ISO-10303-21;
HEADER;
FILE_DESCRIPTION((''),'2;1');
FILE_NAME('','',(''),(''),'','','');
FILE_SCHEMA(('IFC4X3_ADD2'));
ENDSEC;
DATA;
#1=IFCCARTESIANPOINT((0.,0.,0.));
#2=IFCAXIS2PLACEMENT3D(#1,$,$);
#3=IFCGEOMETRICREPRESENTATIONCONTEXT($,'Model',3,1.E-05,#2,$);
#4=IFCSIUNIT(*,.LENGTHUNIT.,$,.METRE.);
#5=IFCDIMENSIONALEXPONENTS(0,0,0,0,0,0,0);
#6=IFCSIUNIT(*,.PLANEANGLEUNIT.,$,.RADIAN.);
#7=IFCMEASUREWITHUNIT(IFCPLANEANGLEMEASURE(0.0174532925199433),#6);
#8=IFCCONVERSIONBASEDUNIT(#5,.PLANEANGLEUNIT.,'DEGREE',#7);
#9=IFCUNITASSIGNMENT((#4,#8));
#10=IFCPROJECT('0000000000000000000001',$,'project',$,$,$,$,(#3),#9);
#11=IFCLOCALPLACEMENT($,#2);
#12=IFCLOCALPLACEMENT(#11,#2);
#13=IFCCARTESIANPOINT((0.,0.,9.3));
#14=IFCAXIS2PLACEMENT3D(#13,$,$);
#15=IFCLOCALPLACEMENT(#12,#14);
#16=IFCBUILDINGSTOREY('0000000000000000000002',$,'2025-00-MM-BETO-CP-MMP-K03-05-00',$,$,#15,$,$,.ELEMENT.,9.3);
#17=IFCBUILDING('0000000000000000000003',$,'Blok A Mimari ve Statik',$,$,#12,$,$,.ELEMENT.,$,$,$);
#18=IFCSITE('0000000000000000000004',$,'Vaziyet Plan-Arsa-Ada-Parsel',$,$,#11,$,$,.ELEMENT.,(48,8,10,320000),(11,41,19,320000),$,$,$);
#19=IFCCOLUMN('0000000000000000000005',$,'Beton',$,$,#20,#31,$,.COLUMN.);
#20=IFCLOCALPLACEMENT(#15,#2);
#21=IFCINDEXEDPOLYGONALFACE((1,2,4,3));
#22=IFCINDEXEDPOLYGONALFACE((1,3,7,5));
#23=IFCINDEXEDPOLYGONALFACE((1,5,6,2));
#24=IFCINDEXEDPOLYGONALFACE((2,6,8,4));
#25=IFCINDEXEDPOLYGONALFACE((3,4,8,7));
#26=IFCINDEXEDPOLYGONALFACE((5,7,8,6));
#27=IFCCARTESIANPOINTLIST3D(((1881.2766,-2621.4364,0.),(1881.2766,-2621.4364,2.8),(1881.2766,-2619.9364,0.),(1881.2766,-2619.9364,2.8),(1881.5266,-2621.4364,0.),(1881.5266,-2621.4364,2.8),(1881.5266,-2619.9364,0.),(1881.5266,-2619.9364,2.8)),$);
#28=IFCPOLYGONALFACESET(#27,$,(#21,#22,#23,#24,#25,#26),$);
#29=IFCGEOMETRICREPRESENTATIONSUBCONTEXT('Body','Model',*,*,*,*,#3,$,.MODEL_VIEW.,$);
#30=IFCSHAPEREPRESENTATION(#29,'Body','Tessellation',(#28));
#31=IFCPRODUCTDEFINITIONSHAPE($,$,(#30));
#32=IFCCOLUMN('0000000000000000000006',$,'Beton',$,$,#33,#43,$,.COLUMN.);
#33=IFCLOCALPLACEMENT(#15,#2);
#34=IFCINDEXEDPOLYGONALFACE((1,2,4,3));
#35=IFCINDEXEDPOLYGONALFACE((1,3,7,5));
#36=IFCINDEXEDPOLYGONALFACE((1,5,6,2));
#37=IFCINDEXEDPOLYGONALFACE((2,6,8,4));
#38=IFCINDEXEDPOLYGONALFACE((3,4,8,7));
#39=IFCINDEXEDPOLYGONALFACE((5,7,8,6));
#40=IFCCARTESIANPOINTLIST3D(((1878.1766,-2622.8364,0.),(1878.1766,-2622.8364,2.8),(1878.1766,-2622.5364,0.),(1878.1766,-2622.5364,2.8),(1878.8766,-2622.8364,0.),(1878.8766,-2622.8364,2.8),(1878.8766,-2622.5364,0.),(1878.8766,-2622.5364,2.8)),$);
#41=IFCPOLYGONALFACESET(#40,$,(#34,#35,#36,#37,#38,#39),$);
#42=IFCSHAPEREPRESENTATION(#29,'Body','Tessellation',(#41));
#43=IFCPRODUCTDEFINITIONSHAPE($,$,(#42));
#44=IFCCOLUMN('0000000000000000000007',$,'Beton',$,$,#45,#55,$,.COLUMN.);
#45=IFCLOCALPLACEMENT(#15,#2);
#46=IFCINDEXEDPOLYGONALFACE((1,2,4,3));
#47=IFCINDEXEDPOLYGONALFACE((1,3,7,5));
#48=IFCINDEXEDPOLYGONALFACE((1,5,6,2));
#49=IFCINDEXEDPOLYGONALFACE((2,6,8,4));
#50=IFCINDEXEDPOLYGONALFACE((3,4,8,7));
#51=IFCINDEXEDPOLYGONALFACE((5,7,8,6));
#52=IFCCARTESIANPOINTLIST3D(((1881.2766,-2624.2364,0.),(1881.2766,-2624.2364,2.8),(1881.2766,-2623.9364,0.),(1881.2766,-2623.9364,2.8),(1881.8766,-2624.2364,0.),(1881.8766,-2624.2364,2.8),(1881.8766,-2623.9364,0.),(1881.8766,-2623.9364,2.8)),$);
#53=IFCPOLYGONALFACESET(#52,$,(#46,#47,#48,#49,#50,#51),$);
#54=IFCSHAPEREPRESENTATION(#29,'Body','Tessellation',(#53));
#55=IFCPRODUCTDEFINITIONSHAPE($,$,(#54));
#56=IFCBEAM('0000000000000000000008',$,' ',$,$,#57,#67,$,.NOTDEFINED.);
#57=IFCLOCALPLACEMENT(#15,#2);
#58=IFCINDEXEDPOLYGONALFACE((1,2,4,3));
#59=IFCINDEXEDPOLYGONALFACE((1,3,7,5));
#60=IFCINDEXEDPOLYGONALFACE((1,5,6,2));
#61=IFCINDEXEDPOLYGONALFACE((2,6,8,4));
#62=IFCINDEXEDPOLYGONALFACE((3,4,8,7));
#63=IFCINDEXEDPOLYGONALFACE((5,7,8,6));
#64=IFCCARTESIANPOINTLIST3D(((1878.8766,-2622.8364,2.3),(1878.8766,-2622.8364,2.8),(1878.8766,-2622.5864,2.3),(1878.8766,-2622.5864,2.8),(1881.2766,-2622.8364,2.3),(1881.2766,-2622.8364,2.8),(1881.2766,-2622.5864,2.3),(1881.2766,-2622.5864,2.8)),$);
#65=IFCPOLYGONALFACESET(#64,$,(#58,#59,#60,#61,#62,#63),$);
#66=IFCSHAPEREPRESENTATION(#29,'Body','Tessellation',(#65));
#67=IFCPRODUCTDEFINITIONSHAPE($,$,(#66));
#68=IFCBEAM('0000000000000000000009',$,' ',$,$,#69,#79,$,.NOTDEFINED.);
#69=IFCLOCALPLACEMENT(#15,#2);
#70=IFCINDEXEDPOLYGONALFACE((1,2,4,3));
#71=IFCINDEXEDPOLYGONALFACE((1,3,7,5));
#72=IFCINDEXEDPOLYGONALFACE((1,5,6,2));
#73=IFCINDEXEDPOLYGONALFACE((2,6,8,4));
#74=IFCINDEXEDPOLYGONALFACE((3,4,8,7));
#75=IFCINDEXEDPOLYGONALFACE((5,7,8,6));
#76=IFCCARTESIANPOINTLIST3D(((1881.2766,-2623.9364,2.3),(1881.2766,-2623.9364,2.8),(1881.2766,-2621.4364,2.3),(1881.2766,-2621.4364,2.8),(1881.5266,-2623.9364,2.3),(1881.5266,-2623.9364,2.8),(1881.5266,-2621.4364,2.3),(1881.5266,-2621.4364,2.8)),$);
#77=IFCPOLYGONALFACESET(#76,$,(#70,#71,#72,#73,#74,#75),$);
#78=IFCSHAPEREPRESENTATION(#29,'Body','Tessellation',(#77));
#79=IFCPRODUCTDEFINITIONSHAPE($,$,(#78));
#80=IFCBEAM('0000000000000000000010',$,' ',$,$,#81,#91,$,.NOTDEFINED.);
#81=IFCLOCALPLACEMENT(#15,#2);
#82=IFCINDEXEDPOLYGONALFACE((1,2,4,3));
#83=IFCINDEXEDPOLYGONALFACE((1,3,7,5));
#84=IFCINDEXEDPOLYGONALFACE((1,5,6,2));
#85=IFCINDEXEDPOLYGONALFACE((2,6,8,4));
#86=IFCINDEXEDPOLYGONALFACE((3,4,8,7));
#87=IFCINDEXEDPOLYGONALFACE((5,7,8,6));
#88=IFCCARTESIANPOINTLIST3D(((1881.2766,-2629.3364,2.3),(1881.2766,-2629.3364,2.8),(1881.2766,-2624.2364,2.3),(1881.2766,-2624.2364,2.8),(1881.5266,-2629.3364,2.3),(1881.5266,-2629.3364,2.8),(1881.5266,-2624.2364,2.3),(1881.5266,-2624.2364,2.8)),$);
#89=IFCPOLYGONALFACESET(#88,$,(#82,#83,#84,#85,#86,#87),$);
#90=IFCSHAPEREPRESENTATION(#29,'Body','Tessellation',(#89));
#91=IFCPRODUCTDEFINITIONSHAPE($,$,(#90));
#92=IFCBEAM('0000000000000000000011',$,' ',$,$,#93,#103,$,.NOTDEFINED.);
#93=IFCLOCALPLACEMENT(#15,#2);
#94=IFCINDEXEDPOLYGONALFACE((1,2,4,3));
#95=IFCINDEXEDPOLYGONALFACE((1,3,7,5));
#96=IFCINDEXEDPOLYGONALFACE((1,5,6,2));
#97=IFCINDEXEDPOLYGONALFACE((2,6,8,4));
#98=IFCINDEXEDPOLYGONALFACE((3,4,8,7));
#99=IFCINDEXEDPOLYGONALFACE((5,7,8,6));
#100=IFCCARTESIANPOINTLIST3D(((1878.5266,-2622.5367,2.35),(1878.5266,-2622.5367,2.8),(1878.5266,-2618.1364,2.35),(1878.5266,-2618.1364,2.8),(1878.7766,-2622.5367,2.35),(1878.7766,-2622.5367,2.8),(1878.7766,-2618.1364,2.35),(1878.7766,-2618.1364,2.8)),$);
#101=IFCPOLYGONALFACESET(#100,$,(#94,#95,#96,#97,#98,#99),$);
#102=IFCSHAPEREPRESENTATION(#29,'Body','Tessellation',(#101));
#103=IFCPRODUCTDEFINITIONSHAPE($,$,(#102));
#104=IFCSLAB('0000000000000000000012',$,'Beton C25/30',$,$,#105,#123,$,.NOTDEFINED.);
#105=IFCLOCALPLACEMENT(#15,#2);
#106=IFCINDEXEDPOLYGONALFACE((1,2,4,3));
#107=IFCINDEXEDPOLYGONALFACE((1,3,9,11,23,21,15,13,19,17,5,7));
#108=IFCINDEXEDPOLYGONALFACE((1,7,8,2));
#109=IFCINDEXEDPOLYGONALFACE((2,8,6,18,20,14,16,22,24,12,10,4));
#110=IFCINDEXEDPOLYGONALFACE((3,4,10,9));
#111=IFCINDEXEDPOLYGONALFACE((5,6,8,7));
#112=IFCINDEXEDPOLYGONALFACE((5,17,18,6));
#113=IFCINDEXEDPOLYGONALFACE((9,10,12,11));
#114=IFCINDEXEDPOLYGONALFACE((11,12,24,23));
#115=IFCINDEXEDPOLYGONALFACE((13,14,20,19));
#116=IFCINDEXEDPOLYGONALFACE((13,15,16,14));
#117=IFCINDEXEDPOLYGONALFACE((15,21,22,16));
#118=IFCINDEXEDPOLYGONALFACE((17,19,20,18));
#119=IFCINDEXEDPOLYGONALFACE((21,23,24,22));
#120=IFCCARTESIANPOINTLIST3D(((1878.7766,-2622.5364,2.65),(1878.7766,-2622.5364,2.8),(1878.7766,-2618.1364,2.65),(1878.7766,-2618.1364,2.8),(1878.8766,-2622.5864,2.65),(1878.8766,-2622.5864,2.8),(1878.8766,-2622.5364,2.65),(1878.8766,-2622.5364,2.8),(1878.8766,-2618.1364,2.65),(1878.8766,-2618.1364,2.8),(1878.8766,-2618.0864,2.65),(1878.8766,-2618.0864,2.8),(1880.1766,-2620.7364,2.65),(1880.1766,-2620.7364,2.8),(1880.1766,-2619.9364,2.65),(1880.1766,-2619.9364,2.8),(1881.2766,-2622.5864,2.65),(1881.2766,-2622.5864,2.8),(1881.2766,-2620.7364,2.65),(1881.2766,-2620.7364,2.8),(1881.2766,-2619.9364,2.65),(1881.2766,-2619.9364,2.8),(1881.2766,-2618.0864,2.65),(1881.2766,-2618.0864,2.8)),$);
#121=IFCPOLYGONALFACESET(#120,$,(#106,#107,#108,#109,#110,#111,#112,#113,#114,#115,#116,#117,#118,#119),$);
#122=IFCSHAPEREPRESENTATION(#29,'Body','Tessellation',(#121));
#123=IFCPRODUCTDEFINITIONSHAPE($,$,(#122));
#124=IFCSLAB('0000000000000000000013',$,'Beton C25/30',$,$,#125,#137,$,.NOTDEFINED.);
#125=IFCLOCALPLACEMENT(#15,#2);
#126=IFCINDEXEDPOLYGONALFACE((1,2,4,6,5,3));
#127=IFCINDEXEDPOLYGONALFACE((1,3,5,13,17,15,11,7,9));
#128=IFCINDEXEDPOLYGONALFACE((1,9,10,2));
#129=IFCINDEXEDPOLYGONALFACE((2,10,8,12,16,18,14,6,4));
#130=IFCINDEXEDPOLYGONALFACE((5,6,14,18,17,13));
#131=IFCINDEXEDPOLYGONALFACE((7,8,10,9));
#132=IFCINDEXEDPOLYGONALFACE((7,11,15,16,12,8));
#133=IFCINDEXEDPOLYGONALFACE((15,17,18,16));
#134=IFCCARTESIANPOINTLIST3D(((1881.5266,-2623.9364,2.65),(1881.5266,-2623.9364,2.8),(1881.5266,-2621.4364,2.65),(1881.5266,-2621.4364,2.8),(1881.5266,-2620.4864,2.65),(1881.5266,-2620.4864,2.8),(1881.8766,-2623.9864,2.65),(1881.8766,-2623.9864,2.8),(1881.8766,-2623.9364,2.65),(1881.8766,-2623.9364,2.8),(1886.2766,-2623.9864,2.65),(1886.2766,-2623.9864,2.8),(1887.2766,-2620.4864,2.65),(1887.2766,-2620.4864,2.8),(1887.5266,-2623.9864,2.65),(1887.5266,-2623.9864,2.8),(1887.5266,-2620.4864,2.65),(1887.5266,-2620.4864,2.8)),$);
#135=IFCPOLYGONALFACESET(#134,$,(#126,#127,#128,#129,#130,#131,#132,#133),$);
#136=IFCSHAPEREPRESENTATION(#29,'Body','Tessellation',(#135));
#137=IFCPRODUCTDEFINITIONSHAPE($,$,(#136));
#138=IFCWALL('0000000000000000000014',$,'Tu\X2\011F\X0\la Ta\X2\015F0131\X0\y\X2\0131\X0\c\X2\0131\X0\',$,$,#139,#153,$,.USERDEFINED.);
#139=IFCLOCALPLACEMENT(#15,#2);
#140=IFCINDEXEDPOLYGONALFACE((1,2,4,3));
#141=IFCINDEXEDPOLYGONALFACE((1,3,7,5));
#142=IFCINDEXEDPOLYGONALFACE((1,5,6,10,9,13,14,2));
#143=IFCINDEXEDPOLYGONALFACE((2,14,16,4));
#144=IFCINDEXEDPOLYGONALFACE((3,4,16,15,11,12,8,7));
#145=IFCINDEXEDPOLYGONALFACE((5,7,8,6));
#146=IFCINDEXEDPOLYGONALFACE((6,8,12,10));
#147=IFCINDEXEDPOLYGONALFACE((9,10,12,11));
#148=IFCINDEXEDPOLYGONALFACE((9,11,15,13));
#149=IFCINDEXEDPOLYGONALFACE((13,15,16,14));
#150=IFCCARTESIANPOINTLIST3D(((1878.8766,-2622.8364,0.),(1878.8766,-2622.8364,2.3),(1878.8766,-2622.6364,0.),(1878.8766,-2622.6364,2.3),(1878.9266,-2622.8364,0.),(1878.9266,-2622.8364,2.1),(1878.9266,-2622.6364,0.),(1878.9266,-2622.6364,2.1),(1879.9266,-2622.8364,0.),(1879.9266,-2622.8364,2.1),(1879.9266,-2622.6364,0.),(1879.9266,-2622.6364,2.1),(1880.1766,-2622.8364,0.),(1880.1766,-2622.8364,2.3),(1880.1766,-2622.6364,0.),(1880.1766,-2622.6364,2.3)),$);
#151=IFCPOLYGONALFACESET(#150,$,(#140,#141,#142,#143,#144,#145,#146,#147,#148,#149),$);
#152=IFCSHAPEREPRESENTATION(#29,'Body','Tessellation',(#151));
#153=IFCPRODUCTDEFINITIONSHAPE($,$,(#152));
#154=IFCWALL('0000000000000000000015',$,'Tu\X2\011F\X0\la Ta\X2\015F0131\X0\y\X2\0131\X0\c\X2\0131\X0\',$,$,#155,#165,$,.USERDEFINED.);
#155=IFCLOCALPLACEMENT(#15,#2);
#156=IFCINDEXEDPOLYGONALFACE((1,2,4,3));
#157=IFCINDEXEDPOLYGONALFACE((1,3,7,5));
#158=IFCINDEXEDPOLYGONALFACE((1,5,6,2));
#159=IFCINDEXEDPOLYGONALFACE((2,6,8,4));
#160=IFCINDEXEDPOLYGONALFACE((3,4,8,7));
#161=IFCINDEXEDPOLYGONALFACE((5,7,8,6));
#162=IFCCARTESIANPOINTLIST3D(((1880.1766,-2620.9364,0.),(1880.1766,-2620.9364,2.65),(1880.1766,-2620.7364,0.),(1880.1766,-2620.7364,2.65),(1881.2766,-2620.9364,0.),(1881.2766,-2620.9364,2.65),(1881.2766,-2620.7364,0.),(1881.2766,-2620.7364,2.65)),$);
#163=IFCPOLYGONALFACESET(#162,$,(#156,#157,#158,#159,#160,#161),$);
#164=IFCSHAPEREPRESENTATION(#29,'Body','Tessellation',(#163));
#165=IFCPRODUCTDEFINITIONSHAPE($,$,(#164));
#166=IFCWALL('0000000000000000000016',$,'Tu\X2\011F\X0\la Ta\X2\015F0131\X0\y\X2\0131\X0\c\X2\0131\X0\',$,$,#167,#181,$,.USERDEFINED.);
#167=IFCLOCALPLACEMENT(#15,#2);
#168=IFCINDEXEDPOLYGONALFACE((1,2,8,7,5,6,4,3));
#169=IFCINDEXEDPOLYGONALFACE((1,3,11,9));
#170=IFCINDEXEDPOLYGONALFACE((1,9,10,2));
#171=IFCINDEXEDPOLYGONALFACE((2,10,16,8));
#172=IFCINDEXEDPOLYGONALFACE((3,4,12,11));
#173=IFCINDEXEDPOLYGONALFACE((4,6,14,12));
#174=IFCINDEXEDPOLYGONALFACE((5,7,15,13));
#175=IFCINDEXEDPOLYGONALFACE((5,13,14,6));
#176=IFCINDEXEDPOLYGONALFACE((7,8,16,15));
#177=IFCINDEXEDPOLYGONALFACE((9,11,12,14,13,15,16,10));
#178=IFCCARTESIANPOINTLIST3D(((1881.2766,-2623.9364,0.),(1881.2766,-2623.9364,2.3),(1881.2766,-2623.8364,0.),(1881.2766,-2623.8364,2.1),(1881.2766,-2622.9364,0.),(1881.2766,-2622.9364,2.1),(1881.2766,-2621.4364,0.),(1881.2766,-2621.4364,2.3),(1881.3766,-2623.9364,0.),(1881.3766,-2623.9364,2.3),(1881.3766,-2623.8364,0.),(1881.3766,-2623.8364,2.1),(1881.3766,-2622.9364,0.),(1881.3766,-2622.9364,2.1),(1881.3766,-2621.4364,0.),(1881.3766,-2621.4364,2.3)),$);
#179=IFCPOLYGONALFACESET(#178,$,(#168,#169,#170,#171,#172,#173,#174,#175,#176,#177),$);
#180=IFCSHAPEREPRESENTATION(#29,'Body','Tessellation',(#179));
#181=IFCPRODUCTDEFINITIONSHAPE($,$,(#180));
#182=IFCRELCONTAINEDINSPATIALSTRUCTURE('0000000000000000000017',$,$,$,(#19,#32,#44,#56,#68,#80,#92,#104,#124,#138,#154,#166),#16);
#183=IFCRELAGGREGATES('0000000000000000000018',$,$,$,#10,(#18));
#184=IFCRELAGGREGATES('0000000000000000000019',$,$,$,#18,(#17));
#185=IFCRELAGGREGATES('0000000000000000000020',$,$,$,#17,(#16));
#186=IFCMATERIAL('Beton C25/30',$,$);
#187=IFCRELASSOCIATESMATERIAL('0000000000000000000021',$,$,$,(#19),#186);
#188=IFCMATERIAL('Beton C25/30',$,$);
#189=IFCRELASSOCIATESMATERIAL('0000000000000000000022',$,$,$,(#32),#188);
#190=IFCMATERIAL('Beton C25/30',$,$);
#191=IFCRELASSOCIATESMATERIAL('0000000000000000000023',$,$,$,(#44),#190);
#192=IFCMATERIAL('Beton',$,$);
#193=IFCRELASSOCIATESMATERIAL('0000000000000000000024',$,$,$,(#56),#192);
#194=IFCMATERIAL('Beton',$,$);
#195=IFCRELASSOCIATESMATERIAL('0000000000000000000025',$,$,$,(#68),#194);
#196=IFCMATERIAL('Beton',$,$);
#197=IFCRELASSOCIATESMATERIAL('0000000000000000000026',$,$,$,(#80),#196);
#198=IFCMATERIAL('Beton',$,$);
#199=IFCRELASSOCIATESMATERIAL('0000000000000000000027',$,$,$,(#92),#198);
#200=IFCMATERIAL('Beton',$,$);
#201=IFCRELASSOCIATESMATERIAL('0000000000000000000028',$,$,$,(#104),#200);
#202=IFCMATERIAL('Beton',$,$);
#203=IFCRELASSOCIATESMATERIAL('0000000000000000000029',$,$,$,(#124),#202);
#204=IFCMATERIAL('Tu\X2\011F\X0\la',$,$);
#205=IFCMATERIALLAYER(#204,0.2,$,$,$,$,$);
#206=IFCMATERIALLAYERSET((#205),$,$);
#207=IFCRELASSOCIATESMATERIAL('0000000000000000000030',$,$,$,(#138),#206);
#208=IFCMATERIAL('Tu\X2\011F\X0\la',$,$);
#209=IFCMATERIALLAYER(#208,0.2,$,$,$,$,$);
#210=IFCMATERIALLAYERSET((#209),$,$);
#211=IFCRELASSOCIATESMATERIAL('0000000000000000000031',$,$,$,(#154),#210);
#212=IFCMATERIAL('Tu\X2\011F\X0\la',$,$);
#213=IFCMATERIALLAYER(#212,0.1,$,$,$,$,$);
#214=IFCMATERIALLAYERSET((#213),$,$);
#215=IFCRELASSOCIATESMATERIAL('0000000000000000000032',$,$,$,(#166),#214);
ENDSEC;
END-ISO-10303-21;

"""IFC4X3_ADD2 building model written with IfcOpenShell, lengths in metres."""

from ifc_helpers import new_model, entity, si_unit, converted_unit, frame, frame_2d, origin, origin_with_axes, place, context, subcontext, project, spatial, polyline, rectangle, outline, extrude, material, layer, layer_set, layer_usage, element, save


model = new_model("IFC4X3_ADD2")

# Units and contexts
model_context = context("Model", 3, precision=1e-05, world=origin())
body_context = subcontext(model_context, "Body", "Model", "MODEL_VIEW")
ifc_project = project(units=[si_unit("LENGTHUNIT", "METRE"), converted_unit("PLANEANGLEUNIT", "DEGREE", entity("IfcPlaneAngleMeasure", 0.0174532925199433), si_unit("PLANEANGLEUNIT", "RADIAN"), dimensions=[0, 0, 0, 0, 0, 0, 0])], contexts=[model_context])

# Site, building, storey
site_placement = place(None, origin())
site = spatial("IfcSite", under=ifc_project, at=site_placement, Name="Vaziyet Plan-Arsa-Ada-Parsel", CompositionType="ELEMENT", RefLatitude=(48, 8, 10, 320000), RefLongitude=(11, 41, 19, 320000))
building_placement = place(site_placement, origin())
building = spatial("IfcBuilding", under=site, at=building_placement, Name="Blok A Mimari ve Statik", CompositionType="ELEMENT")
storey_placement = place(building_placement, frame((0.0, 0.0, 9.3)))
storey = spatial("IfcBuildingStorey", under=building, at=storey_placement, Name="2025-00-MM-BETO-CP-MMP-K03-05-00", CompositionType="ELEMENT", Elevation=9.3)

# Columns
ifc_material_1 = material(Name="Beton C25/30")
column_1_placement = place(storey_placement, frame((1881.2766, -2621.4364, 0.0)))
element("IfcColumn", 1, at=column_1_placement, inside=storey, material=ifc_material_1, Name="Beton", PredefinedType="COLUMN", context=body_context, shape_type="SweptSolid", body=[
    extrude(outline(polyline([(0.0, 0.0), (0.25, 0.0), (0.25, 1.5), (0.0, 1.5), (0.0, 0.0)])), origin_with_axes(), (0.0, 0.0, 1.0), 2.8),
])
ifc_material_2 = material(Name="Beton C25/30")
column_2_placement = place(storey_placement, frame((1878.1766, -2622.8364, 0.0)))
element("IfcColumn", 2, at=column_2_placement, inside=storey, material=ifc_material_2, Name="Beton", PredefinedType="COLUMN", context=body_context, shape_type="SweptSolid", body=[
    extrude(outline(polyline([(0.0, 0.0), (0.7, 0.0), (0.7, 0.3), (0.0, 0.3), (0.0, 0.0)])), origin_with_axes(), (0.0, 0.0, 1.0), 2.8),
])
ifc_material_3 = material(Name="Beton C25/30")
column_3_placement = place(storey_placement, frame((1881.2766, -2624.2364, 0.0)))
element("IfcColumn", 3, at=column_3_placement, inside=storey, material=ifc_material_3, Name="Beton", PredefinedType="COLUMN", context=body_context, shape_type="SweptSolid", body=[
    extrude(outline(polyline([(0.0, 0.0), (0.6, 0.0), (0.6, 0.3), (0.0, 0.3), (0.0, 0.0)])), origin_with_axes(), (0.0, 0.0, 1.0), 2.8),
])

# Beams
ifc_material_4 = material(Name="Beton")
beam_1_placement = place(storey_placement, frame((1878.8766, -2622.8364, 2.3)))
element("IfcBeam", 4, at=beam_1_placement, inside=storey, material=ifc_material_4, Name=" ", PredefinedType="NOTDEFINED", context=body_context, shape_type="SweptSolid", body=[
    extrude(rectangle(XDim=0.25, YDim=0.5, at=frame_2d((0.125, 0.25), x_axis=(1.0, 0.0))), frame((0.0, 0.0, 0.0), z_axis=(1.0, 0.0, 0.0), x_axis=(0.0, 1.0, 0.0)), (0.0, 0.0, 1.0), 2.4),
])
ifc_material_5 = material(Name="Beton")
beam_2_placement = place(storey_placement, frame((1881.2766, -2621.4364, 2.3), z_axis=(0.0, 0.0, 1.0), x_axis=(0.0, -1.0, 0.0)))
element("IfcBeam", 5, at=beam_2_placement, inside=storey, material=ifc_material_5, Name=" ", PredefinedType="NOTDEFINED", context=body_context, shape_type="SweptSolid", body=[
    extrude(rectangle(XDim=0.25, YDim=0.5, at=frame_2d((0.125, 0.25), x_axis=(1.0, 0.0))), frame((0.0, 0.0, 0.0), z_axis=(1.0, 0.0, 0.0), x_axis=(0.0, 1.0, 0.0)), (0.0, 0.0, 1.0), 2.5),
])
ifc_material_6 = material(Name="Beton")
beam_3_placement = place(storey_placement, frame((1881.2766, -2624.2364, 2.3), z_axis=(0.0, 0.0, 1.0), x_axis=(0.0, -1.0, 0.0)))
element("IfcBeam", 6, at=beam_3_placement, inside=storey, material=ifc_material_6, Name=" ", PredefinedType="NOTDEFINED", context=body_context, shape_type="SweptSolid", body=[
    extrude(rectangle(XDim=0.25, YDim=0.5, at=frame_2d((0.125, 0.25), x_axis=(1.0, 0.0))), frame((0.0, 0.0, 0.0), z_axis=(1.0, 0.0, 0.0), x_axis=(0.0, 1.0, 0.0)), (0.0, 0.0, 1.0), 5.1),
])
ifc_material_7 = material(Name="Beton")
beam_4_placement = place(storey_placement, frame((1878.7766, -2622.5367, 2.35), z_axis=(0.0, 0.0, 1.0), x_axis=(0.0, 1.0, 0.0)))
element("IfcBeam", 7, at=beam_4_placement, inside=storey, material=ifc_material_7, Name=" ", PredefinedType="NOTDEFINED", context=body_context, shape_type="SweptSolid", body=[
    extrude(rectangle(XDim=0.25, YDim=0.45, at=frame_2d((0.125, 0.225), x_axis=(1.0, 0.0))), frame((0.0, 0.0, 0.0), z_axis=(1.0, 0.0, 0.0), x_axis=(0.0, 1.0, 0.0)), (0.0, 0.0, 1.0), 4.4003),
])

# Slab, opening
ifc_material_8 = material(Name="Beton")
slab_1_placement = place(storey_placement, frame((1878.7766, -2622.5864, 2.65)))
slab_1 = element("IfcSlab", 8, at=slab_1_placement, inside=storey, material=ifc_material_8, Name="Beton C25/30", PredefinedType="NOTDEFINED", context=body_context, shape_type="SweptSolid", body=[
    extrude(outline(polyline([(0.1, 4.5), (0.1, 4.45), (0.0, 4.45), (0.0, 0.05), (0.1, 0.05), (0.1, 0.0), (2.5, 0.0), (2.5, 4.5), (0.1, 4.5)])), origin_with_axes(), (0.0, 0.0, 1.0), 0.15),
])
opening_1_placement = place(slab_1_placement, frame((1.4, 1.85, 0.0)))
element("IfcOpeningElement", 9, at=opening_1_placement, cuts=slab_1, PredefinedType="OPENING", context=body_context, shape_type="SweptSolid", body=[
    extrude(rectangle(XDim=1.1, YDim=0.8, at=frame_2d((0.0, 0.0), x_axis=(-1.0, 0.0))), frame((0.55, 0.4, 0.0), z_axis=(0.0, 0.0, 1.0), x_axis=(1.0, 0.0, 0.0)), (0.0, 0.0, 1.0), 0.15),
])

# Slab
ifc_material_9 = material(Name="Beton")
slab_2_placement = place(storey_placement, frame((1881.5266, -2623.9864, 2.65)))
element("IfcSlab", 10, at=slab_2_placement, inside=storey, material=ifc_material_9, Name="Beton C25/30", PredefinedType="NOTDEFINED", context=body_context, shape_type="SweptSolid", body=[
    extrude(outline(polyline([(0.0, 3.5), (0.0, 2.55), (0.0, 0.05), (0.35, 0.05), (0.35, 0.0), (4.75, 0.0), (6.0, 0.0), (6.0, 3.5), (5.75, 3.5), (0.0, 3.5)])), origin_with_axes(), (0.0, 0.0, 1.0), 0.15),
])

# Wall, opening
ifc_material_10 = material(Name="Tuğla")
ifc_layer_1 = layer(ifc_material_10, 0.2)
ifc_layer_set_1 = layer_set([ifc_layer_1])
ifc_layer_usage_1 = layer_usage(ifc_layer_set_1, "AXIS2", "POSITIVE", 0.0)
wall_1_placement = place(storey_placement, frame((1878.8766, -2622.8364, 0.0), z_axis=(0.0, 0.0, 1.0), x_axis=(1.0, 0.000001, 0.0)))
wall_1 = element("IfcWall", 11, at=wall_1_placement, inside=storey, material=ifc_layer_usage_1, Name="Tuğla Taşıyıcı", PredefinedType="USERDEFINED", context=body_context, shape_type="SweptSolid", body=[
    extrude(rectangle(XDim=1.3, YDim=0.2, at=frame_2d((0.65, 0.1), x_axis=(1.0, 0.0))), origin_with_axes(), (0.0, 0.0, 1.0), 2.3),
])
opening_2_placement = place(wall_1_placement, frame((0.05, 0.0, 0.0), z_axis=(0.0, 1.0, 0.0), x_axis=(0.0, 0.0, 1.0)))
element("IfcOpeningElement", 12, at=opening_2_placement, cuts=wall_1, PredefinedType="OPENING", context=body_context, shape_type="SweptSolid", body=[
    extrude(outline(polyline([(2.1, 1.0), (2.1, 0.0), (0.0, 0.0), (0.0, 1.0), (2.1, 1.0)])), origin_with_axes(), (0.0, 0.0, 1.0), 0.2),
])

# Wall
ifc_material_11 = material(Name="Tuğla")
ifc_layer_2 = layer(ifc_material_11, 0.2)
ifc_layer_set_2 = layer_set([ifc_layer_2])
ifc_layer_usage_2 = layer_usage(ifc_layer_set_2, "AXIS2", "POSITIVE", 0.0)
wall_2_placement = place(storey_placement, frame((1880.1766, -2620.9364, 0.0)))
element("IfcWall", 13, at=wall_2_placement, inside=storey, material=ifc_layer_usage_2, Name="Tuğla Taşıyıcı", PredefinedType="USERDEFINED", context=body_context, shape_type="SweptSolid", body=[
    extrude(rectangle(XDim=1.1, YDim=0.2, at=frame_2d((0.55, 0.1), x_axis=(1.0, 0.0))), origin_with_axes(), (0.0, 0.0, 1.0), 2.65),
])

# Wall, opening
ifc_material_12 = material(Name="Tuğla")
ifc_layer_3 = layer(ifc_material_12, 0.1)
ifc_layer_set_3 = layer_set([ifc_layer_3])
ifc_layer_usage_3 = layer_usage(ifc_layer_set_3, "AXIS2", "POSITIVE", 0.0)
wall_3_placement = place(storey_placement, frame((1881.2766, -2621.4364, 0.0), z_axis=(0.0, 0.0, 1.0), x_axis=(0.0, -1.0, 0.0)))
wall_3 = element("IfcWall", 14, at=wall_3_placement, inside=storey, material=ifc_layer_usage_3, Name="Tuğla Taşıyıcı", PredefinedType="USERDEFINED", context=body_context, shape_type="SweptSolid", body=[
    extrude(rectangle(XDim=2.5, YDim=0.1, at=frame_2d((1.25, 0.05), x_axis=(1.0, 0.0))), origin_with_axes(), (0.0, 0.0, 1.0), 2.3),
])
opening_3_placement = place(wall_3_placement, frame((2.4, 0.1, 0.0), z_axis=(0.0, -1.0, 0.0), x_axis=(0.0, 0.0, 1.0)))
element("IfcOpeningElement", 15, at=opening_3_placement, cuts=wall_3, PredefinedType="OPENING", context=body_context, shape_type="SweptSolid", body=[
    extrude(outline(polyline([(2.1, 0.9), (2.1, 0.0), (0.0, 0.0), (0.0, 0.9), (2.1, 0.9)])), origin_with_axes(), (0.0, 0.0, 1.0), 0.1),
])

save(model, "model.ifc")
